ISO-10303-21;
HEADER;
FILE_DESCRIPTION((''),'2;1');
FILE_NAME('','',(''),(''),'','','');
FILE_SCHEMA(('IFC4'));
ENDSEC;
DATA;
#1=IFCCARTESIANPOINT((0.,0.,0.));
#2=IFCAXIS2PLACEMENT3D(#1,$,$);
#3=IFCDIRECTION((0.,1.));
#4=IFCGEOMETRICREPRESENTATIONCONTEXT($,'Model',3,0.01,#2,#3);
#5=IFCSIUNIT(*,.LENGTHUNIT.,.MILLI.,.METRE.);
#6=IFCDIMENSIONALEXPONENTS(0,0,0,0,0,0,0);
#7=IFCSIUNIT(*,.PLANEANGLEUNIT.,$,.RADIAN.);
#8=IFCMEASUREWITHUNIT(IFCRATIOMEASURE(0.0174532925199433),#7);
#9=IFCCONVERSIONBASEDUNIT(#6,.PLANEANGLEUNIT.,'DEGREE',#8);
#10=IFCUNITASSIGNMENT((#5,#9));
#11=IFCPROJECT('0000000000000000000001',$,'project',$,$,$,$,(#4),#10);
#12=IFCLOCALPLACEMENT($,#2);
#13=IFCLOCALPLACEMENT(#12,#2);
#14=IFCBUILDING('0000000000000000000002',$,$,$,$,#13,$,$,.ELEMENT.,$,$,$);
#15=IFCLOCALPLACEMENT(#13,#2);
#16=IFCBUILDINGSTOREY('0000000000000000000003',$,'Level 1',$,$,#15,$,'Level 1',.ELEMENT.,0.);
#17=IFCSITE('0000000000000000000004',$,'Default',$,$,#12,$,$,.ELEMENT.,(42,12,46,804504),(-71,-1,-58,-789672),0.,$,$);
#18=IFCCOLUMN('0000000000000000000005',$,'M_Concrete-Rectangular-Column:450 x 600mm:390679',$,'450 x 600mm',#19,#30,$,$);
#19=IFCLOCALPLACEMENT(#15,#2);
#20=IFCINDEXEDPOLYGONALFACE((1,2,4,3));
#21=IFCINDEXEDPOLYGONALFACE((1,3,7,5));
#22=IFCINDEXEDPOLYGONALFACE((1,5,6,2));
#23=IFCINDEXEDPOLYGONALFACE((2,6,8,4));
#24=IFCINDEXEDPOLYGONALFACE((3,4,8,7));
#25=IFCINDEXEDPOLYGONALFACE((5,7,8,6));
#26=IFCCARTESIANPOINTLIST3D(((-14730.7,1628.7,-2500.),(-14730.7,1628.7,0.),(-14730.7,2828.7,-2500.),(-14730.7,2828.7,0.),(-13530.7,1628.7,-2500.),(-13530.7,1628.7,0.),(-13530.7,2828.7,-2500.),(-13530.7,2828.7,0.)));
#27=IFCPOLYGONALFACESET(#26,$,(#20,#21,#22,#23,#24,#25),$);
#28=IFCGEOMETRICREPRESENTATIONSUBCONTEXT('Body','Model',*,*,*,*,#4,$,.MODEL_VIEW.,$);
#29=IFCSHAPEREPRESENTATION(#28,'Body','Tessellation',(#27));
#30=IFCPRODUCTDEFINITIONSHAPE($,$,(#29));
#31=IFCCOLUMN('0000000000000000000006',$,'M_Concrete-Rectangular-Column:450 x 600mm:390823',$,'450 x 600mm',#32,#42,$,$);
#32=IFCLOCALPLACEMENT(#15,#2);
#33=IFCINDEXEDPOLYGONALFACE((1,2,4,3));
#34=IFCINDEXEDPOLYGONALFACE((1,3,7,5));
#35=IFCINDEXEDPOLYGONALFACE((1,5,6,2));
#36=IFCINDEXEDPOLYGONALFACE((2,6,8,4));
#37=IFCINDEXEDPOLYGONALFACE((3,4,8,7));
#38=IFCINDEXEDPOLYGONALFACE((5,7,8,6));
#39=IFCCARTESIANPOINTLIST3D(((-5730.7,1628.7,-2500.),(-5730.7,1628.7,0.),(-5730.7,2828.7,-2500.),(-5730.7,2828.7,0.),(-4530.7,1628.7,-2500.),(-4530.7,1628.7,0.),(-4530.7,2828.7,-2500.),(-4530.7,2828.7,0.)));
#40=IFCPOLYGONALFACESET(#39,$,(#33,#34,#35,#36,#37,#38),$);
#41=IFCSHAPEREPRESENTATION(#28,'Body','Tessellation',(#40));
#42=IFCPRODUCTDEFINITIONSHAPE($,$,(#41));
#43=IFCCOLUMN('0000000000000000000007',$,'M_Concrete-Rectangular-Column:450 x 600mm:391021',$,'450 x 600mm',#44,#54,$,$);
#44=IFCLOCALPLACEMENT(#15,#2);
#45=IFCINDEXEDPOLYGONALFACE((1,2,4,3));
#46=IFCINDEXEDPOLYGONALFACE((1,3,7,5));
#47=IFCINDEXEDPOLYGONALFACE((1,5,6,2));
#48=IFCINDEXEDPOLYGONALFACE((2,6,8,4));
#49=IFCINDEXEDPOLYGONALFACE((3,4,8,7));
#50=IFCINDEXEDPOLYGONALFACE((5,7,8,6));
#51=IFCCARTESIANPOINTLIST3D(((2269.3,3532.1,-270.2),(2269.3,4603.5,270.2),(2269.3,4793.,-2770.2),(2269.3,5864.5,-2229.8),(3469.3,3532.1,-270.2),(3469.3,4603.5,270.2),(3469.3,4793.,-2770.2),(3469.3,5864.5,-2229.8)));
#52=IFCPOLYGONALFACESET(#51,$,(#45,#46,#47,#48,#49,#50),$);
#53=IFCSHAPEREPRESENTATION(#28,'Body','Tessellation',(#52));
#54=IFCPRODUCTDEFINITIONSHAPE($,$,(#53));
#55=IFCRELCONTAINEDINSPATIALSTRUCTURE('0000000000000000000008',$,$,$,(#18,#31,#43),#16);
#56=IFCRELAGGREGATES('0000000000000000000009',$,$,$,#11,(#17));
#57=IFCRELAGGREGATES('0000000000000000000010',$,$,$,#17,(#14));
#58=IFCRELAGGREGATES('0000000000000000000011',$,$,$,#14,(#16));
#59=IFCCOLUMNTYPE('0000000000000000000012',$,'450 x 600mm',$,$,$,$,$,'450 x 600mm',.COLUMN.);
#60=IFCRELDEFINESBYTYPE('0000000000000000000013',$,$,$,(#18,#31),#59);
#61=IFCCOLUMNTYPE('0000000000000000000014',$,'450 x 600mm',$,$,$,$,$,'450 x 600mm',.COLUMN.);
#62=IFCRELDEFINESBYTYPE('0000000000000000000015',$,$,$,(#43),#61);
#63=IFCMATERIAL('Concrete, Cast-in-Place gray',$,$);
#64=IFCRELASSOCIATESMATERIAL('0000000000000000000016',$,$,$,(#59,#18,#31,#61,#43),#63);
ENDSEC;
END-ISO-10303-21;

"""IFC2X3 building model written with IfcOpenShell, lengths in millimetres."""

from ifc_helpers import new_model, entity, si_unit, converted_unit, direction, frame, frame_2d, origin, origin_2d_with_axis, place, context, subcontext, project, spatial, rectangle, extrude, source, transform, mapped, material, type_object, type_shapes, element, save


model = new_model("IFC2X3")

# Units and contexts
model_context = context("Model", 3, precision=0.01, world=origin(), true_north=direction((0.0, 1.0)))
body_context = subcontext(model_context, "Body", "Model", "MODEL_VIEW")
ifc_project = project(units=[si_unit("LENGTHUNIT", "METRE", prefix="MILLI"), converted_unit("PLANEANGLEUNIT", "DEGREE", entity("IfcRatioMeasure", 0.0174532925199433), si_unit("PLANEANGLEUNIT", "RADIAN"), dimensions=[0, 0, 0, 0, 0, 0, 0])], contexts=[model_context])

# Site, building, storey
site_placement = place(None, origin())
site = spatial("IfcSite", under=ifc_project, at=site_placement, Name="Default", CompositionType="ELEMENT", RefLatitude=(42, 12, 46, 804504), RefLongitude=(-71, -1, -58, -789672), RefElevation=0.0)
building_placement = place(site_placement, origin())
building = spatial("IfcBuilding", under=site, at=building_placement, CompositionType="ELEMENT")
storey_placement = place(building_placement, origin())
storey = spatial("IfcBuildingStorey", under=building, at=storey_placement, Name="Level 1", LongName="Level 1", CompositionType="ELEMENT", Elevation=0.0)

# Columns
ifc_material_1 = material(Name="Concrete, Cast-in-Place gray")
column_type_1 = type_object("IfcColumnType", Name="450 x 600mm", ElementType="450 x 600mm", PredefinedType="COLUMN", material=ifc_material_1)
shared_shape_1 = source(origin(), body_context, "Body", "SweptSolid", [
    extrude(rectangle(XDim=1200.0, YDim=1200.0, at=origin_2d_with_axis()), frame((0.0, 0.0, -2500.0), z_axis=(0.0, 0.0, 1.0), x_axis=(0.0, -1.0, 0.0)), (0.0, 0.0, 1.0), 2500.0),
])
type_shapes(column_type_1, [shared_shape_1])
for number, where, name in (
    (1, (-14130.7, 2228.7, 0.0), "M_Concrete-Rectangular-Column:450 x 600mm:390679"),
    (2, (-5130.7, 2228.7, 0.0), "M_Concrete-Rectangular-Column:450 x 600mm:390823"),
):
    element("IfcColumn", number, at=place(storey_placement, frame(where)), inside=storey, type_object=column_type_1, material=ifc_material_1, Name=name, ObjectType="450 x 600mm", context=body_context, shape_type="MappedRepresentation", body=[
        mapped(shared_shape_1, transform((0.0, 0.0, 0.0), scale=1.0)),
    ])
column_type_2 = type_object("IfcColumnType", Name="450 x 600mm", ElementType="450 x 600mm", PredefinedType="COLUMN", material=ifc_material_1)
shared_shape_2 = source(origin(), body_context, "Body", "SweptSolid", [
    extrude(rectangle(XDim=1200.0, YDim=1200.0, at=frame_2d((0.0, 0.0), x_axis=(0.0, 1.0))), frame((2869.3, 5328.7, -2500.0), z_axis=(0.0, -0.45034, 0.892857), x_axis=(-1.0, 0.0, 0.0)), (0.0, 0.0, 1.0), 2800.0),
])
type_shapes(column_type_2, [shared_shape_2])
column_placement = place(storey_placement, origin())
element("IfcColumn", 3, at=column_placement, inside=storey, type_object=column_type_2, material=ifc_material_1, Name="M_Concrete-Rectangular-Column:450 x 600mm:391021", ObjectType="450 x 600mm", context=body_context, shape_type="MappedRepresentation", body=[
    mapped(shared_shape_2, transform((0.0, 0.0, 0.0), scale=1.0)),
])

save(model, "model.ifc")
